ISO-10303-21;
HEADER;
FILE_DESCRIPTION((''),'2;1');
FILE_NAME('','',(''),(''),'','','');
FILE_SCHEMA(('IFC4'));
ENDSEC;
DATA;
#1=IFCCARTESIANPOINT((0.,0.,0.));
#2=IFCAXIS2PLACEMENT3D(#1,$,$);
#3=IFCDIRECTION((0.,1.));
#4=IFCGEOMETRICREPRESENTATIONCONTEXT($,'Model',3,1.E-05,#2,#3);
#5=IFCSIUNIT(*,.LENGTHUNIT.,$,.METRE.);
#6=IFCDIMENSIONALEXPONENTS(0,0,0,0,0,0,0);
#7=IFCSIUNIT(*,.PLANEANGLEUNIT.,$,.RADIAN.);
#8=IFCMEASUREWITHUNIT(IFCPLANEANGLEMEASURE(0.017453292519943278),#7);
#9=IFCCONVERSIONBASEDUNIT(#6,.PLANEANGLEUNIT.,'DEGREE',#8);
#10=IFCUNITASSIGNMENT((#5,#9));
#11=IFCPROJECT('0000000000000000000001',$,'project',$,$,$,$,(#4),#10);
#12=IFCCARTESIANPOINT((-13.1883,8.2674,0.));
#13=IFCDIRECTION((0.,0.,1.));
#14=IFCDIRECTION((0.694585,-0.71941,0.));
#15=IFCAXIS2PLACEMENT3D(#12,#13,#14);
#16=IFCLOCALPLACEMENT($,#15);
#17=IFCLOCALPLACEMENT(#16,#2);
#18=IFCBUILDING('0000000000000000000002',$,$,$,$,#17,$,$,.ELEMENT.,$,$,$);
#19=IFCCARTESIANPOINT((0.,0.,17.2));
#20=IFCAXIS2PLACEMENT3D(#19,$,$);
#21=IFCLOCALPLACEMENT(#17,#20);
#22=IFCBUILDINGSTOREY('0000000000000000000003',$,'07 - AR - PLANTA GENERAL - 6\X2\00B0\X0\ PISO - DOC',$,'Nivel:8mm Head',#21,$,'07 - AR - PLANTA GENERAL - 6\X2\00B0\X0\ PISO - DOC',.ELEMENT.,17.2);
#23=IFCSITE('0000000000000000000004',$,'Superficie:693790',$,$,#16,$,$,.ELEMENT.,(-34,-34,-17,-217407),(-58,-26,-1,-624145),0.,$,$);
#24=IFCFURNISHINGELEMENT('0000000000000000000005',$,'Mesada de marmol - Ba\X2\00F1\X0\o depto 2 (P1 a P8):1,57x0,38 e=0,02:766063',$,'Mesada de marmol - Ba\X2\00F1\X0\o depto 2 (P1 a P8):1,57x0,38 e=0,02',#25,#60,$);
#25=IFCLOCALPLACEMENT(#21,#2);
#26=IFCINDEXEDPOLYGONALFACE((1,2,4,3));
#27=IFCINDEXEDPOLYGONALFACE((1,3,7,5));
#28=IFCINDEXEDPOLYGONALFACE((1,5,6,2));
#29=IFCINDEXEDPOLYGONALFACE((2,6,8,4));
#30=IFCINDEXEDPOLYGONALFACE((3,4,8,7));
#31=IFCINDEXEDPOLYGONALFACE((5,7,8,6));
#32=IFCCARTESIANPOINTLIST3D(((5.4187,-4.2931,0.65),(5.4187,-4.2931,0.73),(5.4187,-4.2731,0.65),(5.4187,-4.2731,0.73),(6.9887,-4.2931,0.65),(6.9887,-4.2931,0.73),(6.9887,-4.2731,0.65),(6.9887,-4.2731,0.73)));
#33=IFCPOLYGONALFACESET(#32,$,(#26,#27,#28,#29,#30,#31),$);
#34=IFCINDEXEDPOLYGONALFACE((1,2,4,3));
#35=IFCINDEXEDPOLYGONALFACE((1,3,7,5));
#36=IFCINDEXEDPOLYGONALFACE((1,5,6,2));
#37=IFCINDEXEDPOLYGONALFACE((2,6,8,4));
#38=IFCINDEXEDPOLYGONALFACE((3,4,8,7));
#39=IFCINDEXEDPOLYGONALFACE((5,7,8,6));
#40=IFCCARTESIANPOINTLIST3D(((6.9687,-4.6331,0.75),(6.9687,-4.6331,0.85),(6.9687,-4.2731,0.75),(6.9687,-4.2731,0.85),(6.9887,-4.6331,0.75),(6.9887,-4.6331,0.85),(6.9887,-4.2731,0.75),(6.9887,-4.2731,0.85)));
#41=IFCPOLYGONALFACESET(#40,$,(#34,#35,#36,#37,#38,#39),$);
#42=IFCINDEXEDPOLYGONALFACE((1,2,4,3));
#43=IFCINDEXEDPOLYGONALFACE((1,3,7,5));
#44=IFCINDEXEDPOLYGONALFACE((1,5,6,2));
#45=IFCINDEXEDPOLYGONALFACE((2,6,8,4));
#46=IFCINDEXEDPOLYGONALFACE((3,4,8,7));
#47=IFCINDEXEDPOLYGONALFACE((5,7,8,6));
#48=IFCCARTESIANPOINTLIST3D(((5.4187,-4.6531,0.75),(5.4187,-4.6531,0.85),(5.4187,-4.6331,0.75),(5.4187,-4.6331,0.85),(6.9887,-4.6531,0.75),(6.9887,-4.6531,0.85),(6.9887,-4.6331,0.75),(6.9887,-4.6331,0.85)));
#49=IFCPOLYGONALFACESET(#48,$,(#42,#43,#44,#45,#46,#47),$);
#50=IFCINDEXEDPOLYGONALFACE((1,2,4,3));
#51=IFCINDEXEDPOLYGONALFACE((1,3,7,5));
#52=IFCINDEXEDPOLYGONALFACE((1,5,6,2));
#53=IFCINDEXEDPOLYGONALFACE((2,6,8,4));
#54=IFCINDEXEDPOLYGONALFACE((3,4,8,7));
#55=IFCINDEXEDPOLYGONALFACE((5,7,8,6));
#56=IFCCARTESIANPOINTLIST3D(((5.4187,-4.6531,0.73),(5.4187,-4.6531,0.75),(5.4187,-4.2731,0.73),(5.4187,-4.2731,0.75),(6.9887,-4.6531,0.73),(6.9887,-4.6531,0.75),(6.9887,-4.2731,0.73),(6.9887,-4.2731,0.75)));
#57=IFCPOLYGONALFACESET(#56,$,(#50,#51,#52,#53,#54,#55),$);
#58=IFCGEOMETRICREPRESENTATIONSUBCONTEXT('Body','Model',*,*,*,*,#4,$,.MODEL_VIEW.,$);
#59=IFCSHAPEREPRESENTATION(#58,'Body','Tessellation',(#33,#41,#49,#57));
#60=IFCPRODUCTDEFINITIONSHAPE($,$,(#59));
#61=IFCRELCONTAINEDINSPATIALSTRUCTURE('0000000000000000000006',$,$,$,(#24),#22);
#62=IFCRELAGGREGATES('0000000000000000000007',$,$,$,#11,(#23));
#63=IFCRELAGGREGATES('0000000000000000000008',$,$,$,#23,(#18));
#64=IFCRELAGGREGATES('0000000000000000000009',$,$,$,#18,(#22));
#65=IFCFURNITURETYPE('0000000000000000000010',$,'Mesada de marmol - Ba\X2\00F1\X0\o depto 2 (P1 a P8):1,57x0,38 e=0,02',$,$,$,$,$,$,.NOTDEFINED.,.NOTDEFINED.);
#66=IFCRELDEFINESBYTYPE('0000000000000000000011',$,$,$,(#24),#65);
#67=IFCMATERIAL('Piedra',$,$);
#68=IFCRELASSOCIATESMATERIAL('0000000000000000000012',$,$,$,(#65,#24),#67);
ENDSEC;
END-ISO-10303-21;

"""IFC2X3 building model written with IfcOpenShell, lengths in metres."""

from ifc_helpers import new_model, entity, si_unit, converted_unit, direction, frame, frame_2d, origin, origin_2d_with_axis, place, context, subcontext, project, spatial, rectangle, extrude, source, transform, mapped, material, type_object, type_shapes, element, save


model = new_model("IFC2X3")

# Units and contexts
model_context = context("Model", 3, precision=1e-05, world=origin(), true_north=direction((0.0, 1.0)))
body_context = subcontext(model_context, "Body", "Model", "MODEL_VIEW")
ifc_project = project(units=[si_unit("LENGTHUNIT", "METRE"), converted_unit("PLANEANGLEUNIT", "DEGREE", entity("IfcPlaneAngleMeasure", 0.017453292519943278), si_unit("PLANEANGLEUNIT", "RADIAN"), dimensions=[0, 0, 0, 0, 0, 0, 0])], contexts=[model_context])

# Site, building, storey
site_placement = place(None, frame((-13.1883, 8.2674, 0.0), z_axis=(0.0, 0.0, 1.0), x_axis=(0.694585, -0.71941, 0.0)))
site = spatial("IfcSite", under=ifc_project, at=site_placement, Name="Superficie:693790", CompositionType="ELEMENT", RefLatitude=(-34, -34, -17, -217407), RefLongitude=(-58, -26, -1, -624145), RefElevation=0.0)
building_placement = place(site_placement, origin())
building = spatial("IfcBuilding", under=site, at=building_placement, CompositionType="ELEMENT")
storey_placement = place(building_placement, frame((0.0, 0.0, 17.2)))
storey = spatial("IfcBuildingStorey", under=building, at=storey_placement, Name="07 - AR - PLANTA GENERAL - 6° PISO - DOC", ObjectType="Nivel:8mm Head", LongName="07 - AR - PLANTA GENERAL - 6° PISO - DOC", CompositionType="ELEMENT", Elevation=17.2)

# Furnishing element
ifc_material_1 = material(Name="Piedra")
furniture_type = type_object("IfcFurnitureType", Name="Mesada de marmol - Baño depto 2 (P1 a P8):1,57x0,38 e=0,02", AssemblyPlace="NOTDEFINED", material=ifc_material_1)
shared_shape_1 = source(origin(), body_context, "Body", "SweptSolid", [
    extrude(rectangle(XDim=0.02, YDim=1.57, at=frame_2d((0.0, 0.0), x_axis=(1.0, 0.0))), frame((-0.4155, -0.37, 0.65), z_axis=(0.0, 0.0, 1.0), x_axis=(0.0, 1.0, 0.0)), (0.0, 0.0, 1.0), 0.08),
    extrude(rectangle(XDim=0.02, YDim=0.36, at=frame_2d((0.0, 0.0), x_axis=(1.0, 0.0))), frame((-1.1905, -0.2, 0.75), z_axis=(0.0, 0.0, 1.0), x_axis=(-1.0, 0.0, 0.0)), (0.0, 0.0, 1.0), 0.1),
    extrude(rectangle(XDim=0.02, YDim=1.57, at=origin_2d_with_axis()), frame((-0.4155, -0.01, 0.75), z_axis=(0.0, 0.0, 1.0), x_axis=(0.0, -1.0, 0.0)), (0.0, 0.0, 1.0), 0.1),
    extrude(rectangle(XDim=1.57, YDim=0.38, at=origin_2d_with_axis()), frame((-0.4155, -0.19, 0.73), z_axis=(0.0, 0.0, 1.0), x_axis=(-1.0, 0.0, 0.0)), (0.0, 0.0, 1.0), 0.02),
])
type_shapes(furniture_type, [shared_shape_1])
furnishing_placement = place(storey_placement, frame((5.7882, -4.6531, 0.0), z_axis=(0.0, 0.0, 1.0), x_axis=(-1.0, 0.0, 0.0)))
element("IfcFurnishingElement", 1, at=furnishing_placement, inside=storey, type_object=furniture_type, material=ifc_material_1, Name="Mesada de marmol - Baño depto 2 (P1 a P8):1,57x0,38 e=0,02:766063", ObjectType="Mesada de marmol - Baño depto 2 (P1 a P8):1,57x0,38 e=0,02", context=body_context, shape_type="MappedRepresentation", body=[
    mapped(shared_shape_1, transform((0.0, 0.0, 0.0), scale=1.0)),
])

save(model, "model.ifc")
